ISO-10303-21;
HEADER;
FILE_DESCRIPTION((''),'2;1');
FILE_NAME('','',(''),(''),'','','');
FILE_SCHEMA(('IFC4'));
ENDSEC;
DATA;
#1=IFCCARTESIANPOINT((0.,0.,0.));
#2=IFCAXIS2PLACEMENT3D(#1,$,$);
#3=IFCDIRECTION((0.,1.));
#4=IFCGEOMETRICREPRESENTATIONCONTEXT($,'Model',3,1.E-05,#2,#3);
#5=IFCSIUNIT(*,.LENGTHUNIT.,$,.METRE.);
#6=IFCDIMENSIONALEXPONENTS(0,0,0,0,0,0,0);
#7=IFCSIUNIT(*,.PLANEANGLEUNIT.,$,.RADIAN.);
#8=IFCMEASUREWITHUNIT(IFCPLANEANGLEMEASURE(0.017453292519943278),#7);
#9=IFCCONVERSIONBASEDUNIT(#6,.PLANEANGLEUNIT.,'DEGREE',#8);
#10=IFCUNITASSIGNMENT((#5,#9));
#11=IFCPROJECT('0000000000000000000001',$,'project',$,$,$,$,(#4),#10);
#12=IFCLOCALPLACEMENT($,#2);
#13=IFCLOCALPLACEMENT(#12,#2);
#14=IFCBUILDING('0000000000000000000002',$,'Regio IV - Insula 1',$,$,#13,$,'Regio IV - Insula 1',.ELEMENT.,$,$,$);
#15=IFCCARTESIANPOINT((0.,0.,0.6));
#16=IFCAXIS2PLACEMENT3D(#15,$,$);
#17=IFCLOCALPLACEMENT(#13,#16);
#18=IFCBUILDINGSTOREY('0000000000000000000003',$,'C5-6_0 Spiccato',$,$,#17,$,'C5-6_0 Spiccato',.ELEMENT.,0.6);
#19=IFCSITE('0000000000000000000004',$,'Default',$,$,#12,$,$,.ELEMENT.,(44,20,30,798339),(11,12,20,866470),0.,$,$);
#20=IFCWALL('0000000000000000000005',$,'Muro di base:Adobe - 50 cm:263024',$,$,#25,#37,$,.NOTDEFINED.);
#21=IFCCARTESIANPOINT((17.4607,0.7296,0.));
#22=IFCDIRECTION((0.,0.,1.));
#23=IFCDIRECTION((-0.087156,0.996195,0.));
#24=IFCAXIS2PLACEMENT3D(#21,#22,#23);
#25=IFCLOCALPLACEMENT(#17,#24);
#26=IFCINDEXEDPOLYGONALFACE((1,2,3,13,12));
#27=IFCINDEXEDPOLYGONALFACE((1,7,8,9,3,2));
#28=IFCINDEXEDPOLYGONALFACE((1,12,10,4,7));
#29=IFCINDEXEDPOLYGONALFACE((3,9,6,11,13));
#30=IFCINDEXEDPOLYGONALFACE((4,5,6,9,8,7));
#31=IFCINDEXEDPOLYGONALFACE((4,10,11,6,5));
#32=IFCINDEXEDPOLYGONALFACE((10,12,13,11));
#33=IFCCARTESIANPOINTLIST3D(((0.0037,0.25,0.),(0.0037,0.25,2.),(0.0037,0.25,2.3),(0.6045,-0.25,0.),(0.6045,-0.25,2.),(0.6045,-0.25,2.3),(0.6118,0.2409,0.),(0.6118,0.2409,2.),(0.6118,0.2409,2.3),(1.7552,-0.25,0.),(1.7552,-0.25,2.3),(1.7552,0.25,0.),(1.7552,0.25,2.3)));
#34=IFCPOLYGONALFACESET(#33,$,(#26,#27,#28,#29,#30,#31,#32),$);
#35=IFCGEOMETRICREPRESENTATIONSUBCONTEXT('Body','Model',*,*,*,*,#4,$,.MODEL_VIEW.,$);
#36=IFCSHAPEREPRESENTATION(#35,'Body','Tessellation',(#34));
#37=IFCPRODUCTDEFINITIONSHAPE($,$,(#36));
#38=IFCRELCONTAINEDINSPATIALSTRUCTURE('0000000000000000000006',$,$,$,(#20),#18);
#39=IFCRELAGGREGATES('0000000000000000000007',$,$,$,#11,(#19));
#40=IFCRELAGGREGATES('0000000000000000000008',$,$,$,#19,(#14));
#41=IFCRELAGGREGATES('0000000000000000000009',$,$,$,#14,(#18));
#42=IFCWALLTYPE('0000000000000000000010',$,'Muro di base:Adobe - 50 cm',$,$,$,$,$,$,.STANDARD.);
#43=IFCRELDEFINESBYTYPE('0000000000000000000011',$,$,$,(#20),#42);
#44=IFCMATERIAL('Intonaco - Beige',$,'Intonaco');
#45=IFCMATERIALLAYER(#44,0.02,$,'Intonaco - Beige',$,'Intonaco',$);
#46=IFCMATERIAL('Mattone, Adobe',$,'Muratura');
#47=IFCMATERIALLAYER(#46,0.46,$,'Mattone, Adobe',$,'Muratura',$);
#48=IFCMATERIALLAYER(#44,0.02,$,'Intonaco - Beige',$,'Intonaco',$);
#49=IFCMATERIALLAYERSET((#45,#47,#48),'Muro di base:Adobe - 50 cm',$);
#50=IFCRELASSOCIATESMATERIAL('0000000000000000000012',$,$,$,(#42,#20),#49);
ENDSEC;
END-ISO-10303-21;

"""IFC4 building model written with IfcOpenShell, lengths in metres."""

from ifc_helpers import new_model, entity, si_unit, converted_unit, direction, frame, frame_2d, origin, place, context, subcontext, project, spatial, polyline, rectangle, outline, extrude, material, layer, layer_set, layer_usage, type_object, element, save


model = new_model("IFC4")

# Units and contexts
model_context = context("Model", 3, precision=1e-05, world=origin(), true_north=direction((0.0, 1.0)))
body_context = subcontext(model_context, "Body", "Model", "MODEL_VIEW")
ifc_project = project(units=[si_unit("LENGTHUNIT", "METRE"), converted_unit("PLANEANGLEUNIT", "DEGREE", entity("IfcPlaneAngleMeasure", 0.017453292519943278), si_unit("PLANEANGLEUNIT", "RADIAN"), dimensions=[0, 0, 0, 0, 0, 0, 0])], contexts=[model_context])

# Site, building, storey
site_placement = place(None, origin())
site = spatial("IfcSite", under=ifc_project, at=site_placement, Name="Default", CompositionType="ELEMENT", RefLatitude=(44, 20, 30, 798339), RefLongitude=(11, 12, 20, 866470), RefElevation=0.0)
building_placement = place(site_placement, origin())
building = spatial("IfcBuilding", under=site, at=building_placement, Name="Regio IV - Insula 1", LongName="Regio IV - Insula 1", CompositionType="ELEMENT")
storey_placement = place(building_placement, frame((0.0, 0.0, 0.6)))
storey = spatial("IfcBuildingStorey", under=building, at=storey_placement, Name="C5-6_0 Spiccato", LongName="C5-6_0 Spiccato", CompositionType="ELEMENT", Elevation=0.6)

# Shared definitions
ifc_material_1 = material(Name="Intonaco - Beige", Category="Intonaco")
ifc_material_2 = material(Name="Mattone, Adobe", Category="Muratura")
ifc_layer_1 = layer(ifc_material_1, 0.02, Name="Intonaco - Beige", Category="Intonaco")
ifc_layer_2 = layer(ifc_material_2, 0.46, Name="Mattone, Adobe", Category="Muratura")
ifc_layer_3 = layer(ifc_material_1, 0.02, Name="Intonaco - Beige", Category="Intonaco")
ifc_layer_set_1 = layer_set([ifc_layer_1, ifc_layer_2, ifc_layer_3], Name="Muro di base:Adobe - 50 cm")
wall_type_1 = type_object("IfcWallType", Name="Muro di base:Adobe - 50 cm", PredefinedType="STANDARD", material=ifc_layer_set_1)

# Wall, opening
ifc_layer_usage_1 = layer_usage(ifc_layer_set_1, "AXIS2", "NEGATIVE", 0.25)
wall_1_placement = place(storey_placement, frame((17.4607, 0.7296, 0.0), z_axis=(0.0, 0.0, 1.0), x_axis=(-0.087156, 0.996195, 0.0)))
wall_1 = element("IfcWall", 1, at=wall_1_placement, inside=storey, type_object=wall_type_1, material=ifc_layer_usage_1, Name="Muro di base:Adobe - 50 cm:263024", PredefinedType="NOTDEFINED", context=body_context, shape_type="SweptSolid", body=[
    extrude(outline(polyline([(0.0037, 0.25), (0.6118, 0.2409), (0.6045, -0.25), (1.7552, -0.25), (1.7552, 0.2463), (1.7552, 0.25), (1.2552, 0.25), (0.0037, 0.25)])), origin(), (0.0, 0.0, 1.0), 2.3),
])
opening_1_placement = place(wall_1_placement, frame((0.795, 17.4579, 0.0)))
element("IfcOpeningElement", 2, at=opening_1_placement, cuts=wall_1, PredefinedType="OPENING", context=body_context, shape_type="SweptSolid", body=[
    extrude(rectangle(XDim=2.0, YDim=1.2361, at=frame_2d((0.0, 0.0), x_axis=(0.0, 1.0))), frame((-0.8086, -17.7077, 1.0), z_axis=(0.014983, 0.999888, 0.0), x_axis=(-0.999888, 0.014983, 0.0)), (0.0, 0.0, 1.0), 0.5),
])

save(model, "model.ifc")
